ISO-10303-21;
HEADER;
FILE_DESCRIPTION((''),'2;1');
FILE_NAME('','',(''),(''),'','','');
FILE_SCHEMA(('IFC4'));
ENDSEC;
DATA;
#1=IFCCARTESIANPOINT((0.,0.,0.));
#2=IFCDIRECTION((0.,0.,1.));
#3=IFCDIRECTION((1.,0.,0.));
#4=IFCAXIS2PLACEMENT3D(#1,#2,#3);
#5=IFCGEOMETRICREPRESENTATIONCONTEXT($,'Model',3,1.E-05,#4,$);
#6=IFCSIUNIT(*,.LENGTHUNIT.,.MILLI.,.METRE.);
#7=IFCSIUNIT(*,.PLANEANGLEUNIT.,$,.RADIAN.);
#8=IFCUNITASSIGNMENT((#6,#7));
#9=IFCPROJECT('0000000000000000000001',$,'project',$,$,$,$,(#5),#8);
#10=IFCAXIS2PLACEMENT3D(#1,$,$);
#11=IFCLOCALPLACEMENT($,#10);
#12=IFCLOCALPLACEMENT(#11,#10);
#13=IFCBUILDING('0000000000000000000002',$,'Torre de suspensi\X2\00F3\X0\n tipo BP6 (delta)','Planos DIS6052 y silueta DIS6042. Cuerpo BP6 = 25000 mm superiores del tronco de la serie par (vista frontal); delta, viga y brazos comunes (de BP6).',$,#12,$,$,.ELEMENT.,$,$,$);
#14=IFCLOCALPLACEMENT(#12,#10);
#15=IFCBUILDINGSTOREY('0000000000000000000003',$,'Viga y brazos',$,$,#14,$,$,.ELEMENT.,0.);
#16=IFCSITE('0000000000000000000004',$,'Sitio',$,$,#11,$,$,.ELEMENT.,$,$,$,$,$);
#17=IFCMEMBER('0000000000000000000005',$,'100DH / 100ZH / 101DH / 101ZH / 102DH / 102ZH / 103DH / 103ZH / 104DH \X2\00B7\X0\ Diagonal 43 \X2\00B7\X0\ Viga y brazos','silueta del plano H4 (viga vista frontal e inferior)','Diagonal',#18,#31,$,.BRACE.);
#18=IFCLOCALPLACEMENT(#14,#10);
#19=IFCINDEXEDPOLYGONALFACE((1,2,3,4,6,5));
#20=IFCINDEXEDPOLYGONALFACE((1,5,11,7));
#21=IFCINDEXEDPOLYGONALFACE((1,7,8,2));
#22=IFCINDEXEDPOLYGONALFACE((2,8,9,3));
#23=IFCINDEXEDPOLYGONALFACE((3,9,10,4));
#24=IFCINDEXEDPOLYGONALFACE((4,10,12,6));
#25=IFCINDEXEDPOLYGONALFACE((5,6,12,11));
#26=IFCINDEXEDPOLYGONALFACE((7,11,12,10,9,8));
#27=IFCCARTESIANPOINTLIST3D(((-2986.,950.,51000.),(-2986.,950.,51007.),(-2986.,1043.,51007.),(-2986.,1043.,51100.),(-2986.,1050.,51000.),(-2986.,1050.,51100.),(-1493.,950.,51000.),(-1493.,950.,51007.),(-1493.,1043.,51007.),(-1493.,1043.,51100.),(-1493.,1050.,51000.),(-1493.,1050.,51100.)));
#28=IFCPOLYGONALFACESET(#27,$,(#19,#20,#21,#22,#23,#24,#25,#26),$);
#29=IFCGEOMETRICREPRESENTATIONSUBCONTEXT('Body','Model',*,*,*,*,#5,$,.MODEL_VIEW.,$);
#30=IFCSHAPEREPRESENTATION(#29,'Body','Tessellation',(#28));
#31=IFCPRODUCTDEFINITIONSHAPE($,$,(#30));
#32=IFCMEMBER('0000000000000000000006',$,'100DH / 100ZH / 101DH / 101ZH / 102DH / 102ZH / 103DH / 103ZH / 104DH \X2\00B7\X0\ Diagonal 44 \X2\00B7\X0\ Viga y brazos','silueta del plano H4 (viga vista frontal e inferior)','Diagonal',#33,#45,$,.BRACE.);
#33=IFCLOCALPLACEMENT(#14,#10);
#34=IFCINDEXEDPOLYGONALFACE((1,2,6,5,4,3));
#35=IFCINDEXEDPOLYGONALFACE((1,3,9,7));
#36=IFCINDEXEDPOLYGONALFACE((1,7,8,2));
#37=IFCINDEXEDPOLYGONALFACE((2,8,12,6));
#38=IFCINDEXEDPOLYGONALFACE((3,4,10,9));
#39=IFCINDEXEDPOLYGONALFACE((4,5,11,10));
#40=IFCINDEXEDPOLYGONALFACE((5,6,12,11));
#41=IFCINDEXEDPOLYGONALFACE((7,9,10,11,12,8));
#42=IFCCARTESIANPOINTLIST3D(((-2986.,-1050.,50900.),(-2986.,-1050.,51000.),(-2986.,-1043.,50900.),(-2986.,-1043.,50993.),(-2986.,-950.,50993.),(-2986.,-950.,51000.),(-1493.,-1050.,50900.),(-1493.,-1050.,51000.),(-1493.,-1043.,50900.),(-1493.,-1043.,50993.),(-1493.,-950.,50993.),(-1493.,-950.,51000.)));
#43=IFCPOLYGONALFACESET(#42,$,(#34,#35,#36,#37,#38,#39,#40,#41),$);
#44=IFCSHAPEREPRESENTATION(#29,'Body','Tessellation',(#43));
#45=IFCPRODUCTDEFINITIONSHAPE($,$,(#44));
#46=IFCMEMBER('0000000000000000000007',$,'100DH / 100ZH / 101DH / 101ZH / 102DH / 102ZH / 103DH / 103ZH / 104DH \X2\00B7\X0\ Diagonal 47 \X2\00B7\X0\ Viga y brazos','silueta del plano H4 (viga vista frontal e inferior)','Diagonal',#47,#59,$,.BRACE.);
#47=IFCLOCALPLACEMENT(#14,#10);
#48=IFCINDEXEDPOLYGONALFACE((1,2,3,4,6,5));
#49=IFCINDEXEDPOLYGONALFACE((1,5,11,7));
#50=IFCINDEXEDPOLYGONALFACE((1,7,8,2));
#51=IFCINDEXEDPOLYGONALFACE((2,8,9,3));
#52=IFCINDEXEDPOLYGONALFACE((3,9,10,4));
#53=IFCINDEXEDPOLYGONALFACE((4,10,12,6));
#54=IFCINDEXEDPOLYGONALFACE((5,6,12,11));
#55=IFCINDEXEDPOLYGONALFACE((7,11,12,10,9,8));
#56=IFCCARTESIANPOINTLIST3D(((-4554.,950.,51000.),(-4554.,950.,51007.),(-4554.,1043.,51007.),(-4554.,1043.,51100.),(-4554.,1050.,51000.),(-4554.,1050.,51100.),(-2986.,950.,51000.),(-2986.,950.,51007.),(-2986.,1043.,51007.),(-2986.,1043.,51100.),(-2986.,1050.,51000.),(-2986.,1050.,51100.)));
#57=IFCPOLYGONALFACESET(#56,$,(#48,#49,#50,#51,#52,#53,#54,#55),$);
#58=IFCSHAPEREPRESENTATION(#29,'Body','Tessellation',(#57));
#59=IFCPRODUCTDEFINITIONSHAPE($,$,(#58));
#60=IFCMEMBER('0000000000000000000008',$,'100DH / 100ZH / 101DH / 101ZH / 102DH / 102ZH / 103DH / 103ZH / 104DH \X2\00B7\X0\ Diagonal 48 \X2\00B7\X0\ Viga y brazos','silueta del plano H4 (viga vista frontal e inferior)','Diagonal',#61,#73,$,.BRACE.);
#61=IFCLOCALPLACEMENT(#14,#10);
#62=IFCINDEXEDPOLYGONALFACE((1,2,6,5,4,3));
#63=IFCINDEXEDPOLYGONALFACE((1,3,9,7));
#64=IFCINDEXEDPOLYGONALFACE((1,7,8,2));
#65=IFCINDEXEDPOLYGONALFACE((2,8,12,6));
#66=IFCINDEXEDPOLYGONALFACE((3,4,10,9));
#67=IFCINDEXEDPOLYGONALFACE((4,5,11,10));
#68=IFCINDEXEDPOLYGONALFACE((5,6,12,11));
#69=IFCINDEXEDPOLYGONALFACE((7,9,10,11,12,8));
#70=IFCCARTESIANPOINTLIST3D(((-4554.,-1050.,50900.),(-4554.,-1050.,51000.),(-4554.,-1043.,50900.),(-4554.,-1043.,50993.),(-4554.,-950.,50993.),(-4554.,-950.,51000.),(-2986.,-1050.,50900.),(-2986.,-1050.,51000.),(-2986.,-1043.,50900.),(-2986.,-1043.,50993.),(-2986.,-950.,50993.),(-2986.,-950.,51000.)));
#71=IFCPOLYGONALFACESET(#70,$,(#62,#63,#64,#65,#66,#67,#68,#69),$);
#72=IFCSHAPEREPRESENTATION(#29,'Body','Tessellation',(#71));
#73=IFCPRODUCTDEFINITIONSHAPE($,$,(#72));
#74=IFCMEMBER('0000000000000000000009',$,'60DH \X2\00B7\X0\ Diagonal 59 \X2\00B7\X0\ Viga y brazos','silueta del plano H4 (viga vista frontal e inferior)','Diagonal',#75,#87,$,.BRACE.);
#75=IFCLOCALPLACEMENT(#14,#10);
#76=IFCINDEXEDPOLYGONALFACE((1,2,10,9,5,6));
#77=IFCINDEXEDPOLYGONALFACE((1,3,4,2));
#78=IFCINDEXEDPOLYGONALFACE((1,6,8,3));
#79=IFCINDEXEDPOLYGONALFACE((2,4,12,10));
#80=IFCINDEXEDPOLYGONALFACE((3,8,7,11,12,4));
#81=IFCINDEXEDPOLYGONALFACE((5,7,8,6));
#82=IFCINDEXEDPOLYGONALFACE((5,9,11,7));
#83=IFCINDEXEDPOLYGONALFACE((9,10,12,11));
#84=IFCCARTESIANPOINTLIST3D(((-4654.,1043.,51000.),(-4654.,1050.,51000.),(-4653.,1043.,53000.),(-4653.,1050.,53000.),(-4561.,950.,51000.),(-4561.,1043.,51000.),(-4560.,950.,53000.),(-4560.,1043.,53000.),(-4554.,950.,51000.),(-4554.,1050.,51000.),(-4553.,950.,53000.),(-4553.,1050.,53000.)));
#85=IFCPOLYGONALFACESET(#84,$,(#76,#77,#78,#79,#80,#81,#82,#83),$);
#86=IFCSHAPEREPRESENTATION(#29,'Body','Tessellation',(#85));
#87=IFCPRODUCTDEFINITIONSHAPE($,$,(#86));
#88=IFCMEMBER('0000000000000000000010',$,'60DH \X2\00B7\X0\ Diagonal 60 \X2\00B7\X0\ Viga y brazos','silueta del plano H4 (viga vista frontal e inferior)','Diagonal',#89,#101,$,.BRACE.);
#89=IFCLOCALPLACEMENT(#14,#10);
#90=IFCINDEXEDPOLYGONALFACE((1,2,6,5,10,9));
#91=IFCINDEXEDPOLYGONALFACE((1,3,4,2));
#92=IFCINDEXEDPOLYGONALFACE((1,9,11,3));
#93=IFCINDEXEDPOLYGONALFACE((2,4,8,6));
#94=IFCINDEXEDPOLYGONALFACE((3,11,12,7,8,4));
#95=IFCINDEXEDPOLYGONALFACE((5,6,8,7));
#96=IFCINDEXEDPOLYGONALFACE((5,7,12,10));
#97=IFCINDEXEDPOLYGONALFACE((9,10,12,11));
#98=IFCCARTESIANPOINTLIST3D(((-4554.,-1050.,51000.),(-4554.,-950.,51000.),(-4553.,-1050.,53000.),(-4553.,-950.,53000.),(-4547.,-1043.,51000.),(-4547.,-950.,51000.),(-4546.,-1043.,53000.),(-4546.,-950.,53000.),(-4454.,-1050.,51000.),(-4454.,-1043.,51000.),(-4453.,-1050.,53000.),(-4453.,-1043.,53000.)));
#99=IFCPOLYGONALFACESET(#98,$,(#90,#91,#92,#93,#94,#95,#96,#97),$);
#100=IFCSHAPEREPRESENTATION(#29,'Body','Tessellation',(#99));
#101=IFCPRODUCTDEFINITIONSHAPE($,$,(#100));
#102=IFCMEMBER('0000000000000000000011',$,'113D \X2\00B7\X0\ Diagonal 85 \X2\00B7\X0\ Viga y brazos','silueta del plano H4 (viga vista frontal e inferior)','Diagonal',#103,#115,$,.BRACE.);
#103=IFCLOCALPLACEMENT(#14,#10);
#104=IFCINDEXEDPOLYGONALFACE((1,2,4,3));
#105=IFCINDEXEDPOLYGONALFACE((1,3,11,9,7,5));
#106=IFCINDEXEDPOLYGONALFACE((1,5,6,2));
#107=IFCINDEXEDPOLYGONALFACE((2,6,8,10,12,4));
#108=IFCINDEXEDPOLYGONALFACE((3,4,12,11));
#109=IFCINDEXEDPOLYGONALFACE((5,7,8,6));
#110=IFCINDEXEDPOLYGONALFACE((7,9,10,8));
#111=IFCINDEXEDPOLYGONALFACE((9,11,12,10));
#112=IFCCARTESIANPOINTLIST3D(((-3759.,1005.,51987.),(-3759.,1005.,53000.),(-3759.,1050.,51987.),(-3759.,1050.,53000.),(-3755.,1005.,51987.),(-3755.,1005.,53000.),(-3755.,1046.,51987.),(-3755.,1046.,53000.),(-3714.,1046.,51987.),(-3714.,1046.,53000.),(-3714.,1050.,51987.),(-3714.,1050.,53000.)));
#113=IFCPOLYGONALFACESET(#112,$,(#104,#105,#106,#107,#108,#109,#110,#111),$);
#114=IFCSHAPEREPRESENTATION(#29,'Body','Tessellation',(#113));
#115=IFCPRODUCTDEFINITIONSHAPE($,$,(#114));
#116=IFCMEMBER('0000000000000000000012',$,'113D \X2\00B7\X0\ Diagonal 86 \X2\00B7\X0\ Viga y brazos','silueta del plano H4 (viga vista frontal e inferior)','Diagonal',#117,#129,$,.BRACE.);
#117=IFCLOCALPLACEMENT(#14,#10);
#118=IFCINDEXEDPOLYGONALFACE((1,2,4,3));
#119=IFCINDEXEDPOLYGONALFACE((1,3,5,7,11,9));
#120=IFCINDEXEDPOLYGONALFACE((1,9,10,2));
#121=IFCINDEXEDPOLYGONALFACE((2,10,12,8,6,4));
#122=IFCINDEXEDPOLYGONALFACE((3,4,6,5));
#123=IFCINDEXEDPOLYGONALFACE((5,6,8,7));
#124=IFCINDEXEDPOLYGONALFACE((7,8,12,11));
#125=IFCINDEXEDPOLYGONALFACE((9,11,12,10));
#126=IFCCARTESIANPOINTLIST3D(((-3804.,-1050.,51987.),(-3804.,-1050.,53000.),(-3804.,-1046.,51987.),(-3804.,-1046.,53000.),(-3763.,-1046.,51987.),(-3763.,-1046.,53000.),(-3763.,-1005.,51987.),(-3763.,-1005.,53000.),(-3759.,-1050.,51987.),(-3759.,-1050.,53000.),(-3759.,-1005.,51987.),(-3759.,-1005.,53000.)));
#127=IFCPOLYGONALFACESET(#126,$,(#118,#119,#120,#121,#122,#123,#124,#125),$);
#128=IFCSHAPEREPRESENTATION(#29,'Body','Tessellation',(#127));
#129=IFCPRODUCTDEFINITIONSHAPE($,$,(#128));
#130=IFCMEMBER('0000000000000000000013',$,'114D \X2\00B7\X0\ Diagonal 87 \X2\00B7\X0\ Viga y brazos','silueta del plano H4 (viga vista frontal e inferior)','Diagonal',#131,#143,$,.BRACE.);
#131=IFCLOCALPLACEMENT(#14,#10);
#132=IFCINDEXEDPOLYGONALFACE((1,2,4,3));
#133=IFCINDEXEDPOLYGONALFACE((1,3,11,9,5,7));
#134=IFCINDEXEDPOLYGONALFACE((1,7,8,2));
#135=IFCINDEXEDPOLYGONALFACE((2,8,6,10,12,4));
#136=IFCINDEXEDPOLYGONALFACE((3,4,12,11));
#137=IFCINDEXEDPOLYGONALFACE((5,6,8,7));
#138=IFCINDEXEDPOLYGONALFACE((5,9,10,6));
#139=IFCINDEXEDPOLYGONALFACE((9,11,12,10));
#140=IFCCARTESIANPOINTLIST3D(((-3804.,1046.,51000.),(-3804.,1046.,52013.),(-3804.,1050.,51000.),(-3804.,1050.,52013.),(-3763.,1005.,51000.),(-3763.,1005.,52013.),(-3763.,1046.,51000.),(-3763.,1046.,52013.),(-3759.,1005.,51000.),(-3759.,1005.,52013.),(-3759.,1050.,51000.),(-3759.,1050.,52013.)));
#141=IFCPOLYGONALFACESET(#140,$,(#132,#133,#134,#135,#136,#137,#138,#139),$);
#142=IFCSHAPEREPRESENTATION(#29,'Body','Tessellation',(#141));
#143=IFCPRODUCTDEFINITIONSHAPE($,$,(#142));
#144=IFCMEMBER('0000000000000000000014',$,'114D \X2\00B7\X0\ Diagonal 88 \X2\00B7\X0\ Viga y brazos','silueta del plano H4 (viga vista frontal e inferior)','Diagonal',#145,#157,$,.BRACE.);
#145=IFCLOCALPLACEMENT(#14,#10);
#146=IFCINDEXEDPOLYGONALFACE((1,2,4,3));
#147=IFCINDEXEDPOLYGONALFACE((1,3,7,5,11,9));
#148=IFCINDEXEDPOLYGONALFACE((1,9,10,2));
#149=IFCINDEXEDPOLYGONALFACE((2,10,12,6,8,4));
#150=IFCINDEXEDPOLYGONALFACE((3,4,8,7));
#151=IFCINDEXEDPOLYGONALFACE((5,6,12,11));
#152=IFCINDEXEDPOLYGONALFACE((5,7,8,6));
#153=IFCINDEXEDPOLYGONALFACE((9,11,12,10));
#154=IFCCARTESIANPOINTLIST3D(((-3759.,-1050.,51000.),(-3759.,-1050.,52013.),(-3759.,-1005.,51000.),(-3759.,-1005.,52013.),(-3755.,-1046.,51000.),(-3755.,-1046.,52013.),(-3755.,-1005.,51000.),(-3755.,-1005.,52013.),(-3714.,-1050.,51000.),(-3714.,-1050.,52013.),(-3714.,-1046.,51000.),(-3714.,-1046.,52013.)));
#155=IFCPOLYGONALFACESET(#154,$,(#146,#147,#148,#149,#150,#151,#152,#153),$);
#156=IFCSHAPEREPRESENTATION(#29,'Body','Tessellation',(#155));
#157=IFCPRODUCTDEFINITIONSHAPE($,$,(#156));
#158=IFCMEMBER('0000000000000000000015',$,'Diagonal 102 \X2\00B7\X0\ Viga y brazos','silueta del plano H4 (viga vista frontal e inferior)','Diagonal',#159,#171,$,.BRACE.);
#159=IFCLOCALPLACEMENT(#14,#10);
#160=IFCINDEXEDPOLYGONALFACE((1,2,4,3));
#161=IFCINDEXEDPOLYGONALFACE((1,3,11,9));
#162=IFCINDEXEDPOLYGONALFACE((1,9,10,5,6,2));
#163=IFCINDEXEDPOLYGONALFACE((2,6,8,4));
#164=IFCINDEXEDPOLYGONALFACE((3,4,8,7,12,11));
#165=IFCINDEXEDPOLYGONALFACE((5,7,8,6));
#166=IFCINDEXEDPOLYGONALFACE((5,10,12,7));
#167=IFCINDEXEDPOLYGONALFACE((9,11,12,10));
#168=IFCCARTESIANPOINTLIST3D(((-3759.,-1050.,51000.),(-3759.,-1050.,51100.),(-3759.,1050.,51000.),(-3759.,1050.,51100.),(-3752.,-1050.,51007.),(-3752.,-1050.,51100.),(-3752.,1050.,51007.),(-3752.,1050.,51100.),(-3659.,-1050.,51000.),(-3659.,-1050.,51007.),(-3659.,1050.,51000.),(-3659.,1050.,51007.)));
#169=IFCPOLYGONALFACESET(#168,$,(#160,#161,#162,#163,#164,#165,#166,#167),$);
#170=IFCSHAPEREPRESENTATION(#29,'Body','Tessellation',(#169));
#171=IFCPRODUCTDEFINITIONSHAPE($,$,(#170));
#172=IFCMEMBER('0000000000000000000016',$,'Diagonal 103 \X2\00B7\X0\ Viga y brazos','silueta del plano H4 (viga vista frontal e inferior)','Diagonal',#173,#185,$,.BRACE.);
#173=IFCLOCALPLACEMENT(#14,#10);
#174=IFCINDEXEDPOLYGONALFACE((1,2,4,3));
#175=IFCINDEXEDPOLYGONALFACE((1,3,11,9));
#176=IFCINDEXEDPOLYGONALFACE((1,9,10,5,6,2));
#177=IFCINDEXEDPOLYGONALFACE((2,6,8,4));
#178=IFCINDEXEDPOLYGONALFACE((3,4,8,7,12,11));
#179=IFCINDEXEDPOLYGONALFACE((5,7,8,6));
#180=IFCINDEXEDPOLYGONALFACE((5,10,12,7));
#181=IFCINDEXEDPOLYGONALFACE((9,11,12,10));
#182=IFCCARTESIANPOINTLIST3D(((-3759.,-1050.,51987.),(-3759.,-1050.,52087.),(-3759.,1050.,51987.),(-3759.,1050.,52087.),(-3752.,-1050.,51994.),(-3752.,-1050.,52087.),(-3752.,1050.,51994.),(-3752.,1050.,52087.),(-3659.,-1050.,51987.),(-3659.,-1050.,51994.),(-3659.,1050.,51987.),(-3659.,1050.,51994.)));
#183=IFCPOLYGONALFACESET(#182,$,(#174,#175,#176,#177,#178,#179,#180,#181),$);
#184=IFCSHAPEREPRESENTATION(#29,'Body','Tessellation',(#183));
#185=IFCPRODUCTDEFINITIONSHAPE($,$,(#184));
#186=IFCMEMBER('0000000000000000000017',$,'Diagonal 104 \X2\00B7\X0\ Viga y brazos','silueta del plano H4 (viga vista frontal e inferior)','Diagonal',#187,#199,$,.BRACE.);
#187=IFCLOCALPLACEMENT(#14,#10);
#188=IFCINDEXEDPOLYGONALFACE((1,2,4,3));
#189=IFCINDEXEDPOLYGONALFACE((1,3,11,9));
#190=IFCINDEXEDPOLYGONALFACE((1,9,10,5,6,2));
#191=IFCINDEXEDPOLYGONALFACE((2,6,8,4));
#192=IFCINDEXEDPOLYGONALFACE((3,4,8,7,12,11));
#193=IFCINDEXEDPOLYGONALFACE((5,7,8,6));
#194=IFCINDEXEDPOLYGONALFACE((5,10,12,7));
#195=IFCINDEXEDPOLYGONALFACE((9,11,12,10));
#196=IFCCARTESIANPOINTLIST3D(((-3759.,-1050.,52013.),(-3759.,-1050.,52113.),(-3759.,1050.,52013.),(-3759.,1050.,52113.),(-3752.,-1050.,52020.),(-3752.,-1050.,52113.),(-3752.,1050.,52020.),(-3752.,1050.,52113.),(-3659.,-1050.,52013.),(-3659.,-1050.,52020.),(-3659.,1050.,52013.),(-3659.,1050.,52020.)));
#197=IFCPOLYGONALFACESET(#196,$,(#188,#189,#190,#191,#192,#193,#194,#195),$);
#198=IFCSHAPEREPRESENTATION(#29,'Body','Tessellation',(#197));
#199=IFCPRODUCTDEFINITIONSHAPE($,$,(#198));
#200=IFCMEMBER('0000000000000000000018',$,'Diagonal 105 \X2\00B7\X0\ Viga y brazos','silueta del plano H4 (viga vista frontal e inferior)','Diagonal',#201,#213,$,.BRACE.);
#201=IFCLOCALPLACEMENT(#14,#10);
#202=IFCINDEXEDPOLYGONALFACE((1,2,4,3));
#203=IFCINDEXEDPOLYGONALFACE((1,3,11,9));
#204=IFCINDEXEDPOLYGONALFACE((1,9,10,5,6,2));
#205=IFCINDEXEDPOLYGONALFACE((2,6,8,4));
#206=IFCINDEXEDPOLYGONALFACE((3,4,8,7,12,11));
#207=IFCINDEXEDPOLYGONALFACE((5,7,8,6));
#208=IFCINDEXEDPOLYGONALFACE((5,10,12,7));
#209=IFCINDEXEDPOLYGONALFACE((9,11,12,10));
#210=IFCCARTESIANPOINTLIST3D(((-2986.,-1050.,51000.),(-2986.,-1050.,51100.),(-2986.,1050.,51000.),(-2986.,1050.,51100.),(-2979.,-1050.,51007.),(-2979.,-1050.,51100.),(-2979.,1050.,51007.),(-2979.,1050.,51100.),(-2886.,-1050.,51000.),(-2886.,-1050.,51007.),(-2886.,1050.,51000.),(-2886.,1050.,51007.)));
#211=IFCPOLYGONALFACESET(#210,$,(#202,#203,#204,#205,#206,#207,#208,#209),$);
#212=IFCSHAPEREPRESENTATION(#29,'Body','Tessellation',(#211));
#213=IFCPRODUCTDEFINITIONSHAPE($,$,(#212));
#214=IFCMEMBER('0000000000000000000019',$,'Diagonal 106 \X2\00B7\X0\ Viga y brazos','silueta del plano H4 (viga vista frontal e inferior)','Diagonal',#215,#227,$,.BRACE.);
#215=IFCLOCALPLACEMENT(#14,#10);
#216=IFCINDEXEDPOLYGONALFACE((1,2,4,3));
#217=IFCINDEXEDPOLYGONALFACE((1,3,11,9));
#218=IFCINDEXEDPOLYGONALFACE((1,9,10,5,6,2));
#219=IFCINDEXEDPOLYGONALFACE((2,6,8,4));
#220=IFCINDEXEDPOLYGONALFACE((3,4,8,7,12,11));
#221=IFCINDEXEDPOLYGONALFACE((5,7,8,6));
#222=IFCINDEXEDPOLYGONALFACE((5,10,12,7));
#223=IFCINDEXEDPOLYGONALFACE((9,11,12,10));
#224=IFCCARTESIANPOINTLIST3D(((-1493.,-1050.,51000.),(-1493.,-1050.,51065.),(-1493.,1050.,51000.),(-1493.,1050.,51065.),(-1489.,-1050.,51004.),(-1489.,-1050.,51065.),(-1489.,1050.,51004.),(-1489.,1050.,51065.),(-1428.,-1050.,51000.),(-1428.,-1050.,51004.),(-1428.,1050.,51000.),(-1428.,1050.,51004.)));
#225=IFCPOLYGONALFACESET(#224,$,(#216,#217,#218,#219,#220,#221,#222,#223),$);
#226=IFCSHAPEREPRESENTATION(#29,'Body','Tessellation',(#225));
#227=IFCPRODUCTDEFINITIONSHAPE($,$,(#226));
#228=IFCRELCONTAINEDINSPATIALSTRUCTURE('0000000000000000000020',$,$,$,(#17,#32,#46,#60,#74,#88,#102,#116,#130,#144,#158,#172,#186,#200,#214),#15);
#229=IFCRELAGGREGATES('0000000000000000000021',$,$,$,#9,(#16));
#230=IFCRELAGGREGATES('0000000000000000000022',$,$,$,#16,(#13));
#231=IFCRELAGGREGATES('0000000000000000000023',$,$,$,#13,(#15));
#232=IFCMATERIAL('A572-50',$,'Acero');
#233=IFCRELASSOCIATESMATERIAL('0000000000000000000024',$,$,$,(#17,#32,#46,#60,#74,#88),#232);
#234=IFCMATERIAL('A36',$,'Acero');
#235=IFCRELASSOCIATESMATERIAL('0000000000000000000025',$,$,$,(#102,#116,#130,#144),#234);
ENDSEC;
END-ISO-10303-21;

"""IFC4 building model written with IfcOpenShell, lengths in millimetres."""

from ifc_helpers import new_model, si_unit, frame, frame_2d, origin, origin_with_axes, place, context, subcontext, project, spatial, l_section, extrude, material, element, save


model = new_model("IFC4")

# Units and contexts
model_context = context("Model", 3, precision=1e-05, world=origin_with_axes())
body_context = subcontext(model_context, "Body", "Model", "MODEL_VIEW")
ifc_project = project(units=[si_unit("LENGTHUNIT", "METRE", prefix="MILLI"), si_unit("PLANEANGLEUNIT", "RADIAN")], contexts=[model_context])

# Site, building, storey
site_placement = place(None, origin())
site = spatial("IfcSite", under=ifc_project, at=site_placement, Name="Sitio", CompositionType="ELEMENT")
building_placement = place(site_placement, origin())
building = spatial("IfcBuilding", under=site, at=building_placement, Name="Torre de suspensión tipo BP6 (delta)", Description="Planos DIS6052 y silueta DIS6042. Cuerpo BP6 = 25000 mm superiores del tronco de la serie par (vista frontal); delta, viga y brazos comunes (de BP6).", CompositionType="ELEMENT")
storey_placement = place(building_placement, origin())
storey = spatial("IfcBuildingStorey", under=building, at=storey_placement, Name="Viga y brazos", CompositionType="ELEMENT", Elevation=0.0)

# Members
ifc_material_1 = material(Name="A572-50", Category="Acero")
ifc_material_2 = material(Name="A36", Category="Acero")
for number, where, z_axis, x_axis, name in (
    (1, (-1493.0, 1050.0, 51000.0), (-1.0, 0.0, 0.0), (0.0, -1.0, 0.0), "100DH / 100ZH / 101DH / 101ZH / 102DH / 102ZH / 103DH / 103ZH / 104DH · Diagonal 43 · Viga y brazos"),
    (2, (-1493.0, -1050.0, 51000.0), (-1.0, 0.0, 0.0), (0.0, 1.0, 0.0), "100DH / 100ZH / 101DH / 101ZH / 102DH / 102ZH / 103DH / 103ZH / 104DH · Diagonal 44 · Viga y brazos"),
):
    element("IfcMember", number, at=place(storey_placement, frame(where, z_axis=z_axis, x_axis=x_axis)), inside=storey, material=ifc_material_1, Name=name, Description="silueta del plano H4 (viga vista frontal e inferior)", ObjectType="Diagonal", PredefinedType="BRACE", context=body_context, shape_type="SweptSolid", body=[
        extrude(l_section(Depth=100.0, Width=100.0, Thickness=7.0, at=frame_2d((50.0, 50.0))), None, (0.0, 0.0, 1.0), 1493.0),
    ])
for number, where, z_axis, x_axis, name in (
    (3, (-2986.0, 1050.0, 51000.0), (-1.0, 0.0, 0.0), (0.0, -1.0, 0.0), "100DH / 100ZH / 101DH / 101ZH / 102DH / 102ZH / 103DH / 103ZH / 104DH · Diagonal 47 · Viga y brazos"),
    (4, (-2986.0, -1050.0, 51000.0), (-1.0, 0.0, 0.0), (0.0, 1.0, 0.0), "100DH / 100ZH / 101DH / 101ZH / 102DH / 102ZH / 103DH / 103ZH / 104DH · Diagonal 48 · Viga y brazos"),
):
    element("IfcMember", number, at=place(storey_placement, frame(where, z_axis=z_axis, x_axis=x_axis)), inside=storey, material=ifc_material_1, Name=name, Description="silueta del plano H4 (viga vista frontal e inferior)", ObjectType="Diagonal", PredefinedType="BRACE", context=body_context, shape_type="SweptSolid", body=[
        extrude(l_section(Depth=100.0, Width=100.0, Thickness=7.0, at=frame_2d((50.0, 50.0))), None, (0.0, 0.0, 1.0), 1568.0),
    ])
for number, where, z_axis, x_axis, name in (
    (5, (-4553.0, 1050.0, 53000.0), (-0.0005, 0.0, -1.0), (0.0, -1.0, 0.0), "60DH · Diagonal 59 · Viga y brazos"),
    (6, (-4553.0, -1050.0, 53000.0), (-0.0005, 0.0, -1.0), (0.0, 1.0, 0.0), "60DH · Diagonal 60 · Viga y brazos"),
):
    element("IfcMember", number, at=place(storey_placement, frame(where, z_axis=z_axis, x_axis=x_axis)), inside=storey, material=ifc_material_1, Name=name, Description="silueta del plano H4 (viga vista frontal e inferior)", ObjectType="Diagonal", PredefinedType="BRACE", context=body_context, shape_type="SweptSolid", body=[
        extrude(l_section(Depth=100.0, Width=100.0, Thickness=7.0, at=frame_2d((50.0, 50.0))), None, (0.0, 0.0, 1.0), 2000.0),
    ])
for number, where, z_axis, x_axis, name in (
    (7, (-3759.0, 1050.0, 51987.0), (0.0, 0.0, 1.0), (0.0, -1.0, 0.0), "113D · Diagonal 85 · Viga y brazos"),
    (8, (-3759.0, -1050.0, 51987.0), (0.0, 0.0, 1.0), (0.0, 1.0, 0.0), "113D · Diagonal 86 · Viga y brazos"),
    (9, (-3759.0, 1050.0, 52013.0), (0.0, 0.0, -1.0), (0.0, -1.0, 0.0), "114D · Diagonal 87 · Viga y brazos"),
    (10, (-3759.0, -1050.0, 52013.0), (0.0, 0.0, -1.0), (0.0, 1.0, 0.0), "114D · Diagonal 88 · Viga y brazos"),
):
    element("IfcMember", number, at=place(storey_placement, frame(where, z_axis=z_axis, x_axis=x_axis)), inside=storey, material=ifc_material_2, Name=name, Description="silueta del plano H4 (viga vista frontal e inferior)", ObjectType="Diagonal", PredefinedType="BRACE", context=body_context, shape_type="SweptSolid", body=[
        extrude(l_section(Depth=45.0, Width=45.0, Thickness=4.0, at=frame_2d((22.5, 22.5))), None, (0.0, 0.0, 1.0), 1013.0),
    ])
for number, where, z_axis, x_axis, name in (
    (11, (-3759.0, 1050.0, 51000.0), (0.0, -1.0, 0.0), (1.0, 0.0, 0.0), "Diagonal 102 · Viga y brazos"),
    (12, (-3759.0, 1050.0, 51987.0), (0.0, -1.0, 0.0), (1.0, 0.0, 0.0), "Diagonal 103 · Viga y brazos"),
    (13, (-3759.0, 1050.0, 52013.0), (0.0, -1.0, 0.0), (1.0, 0.0, 0.0), "Diagonal 104 · Viga y brazos"),
    (14, (-2986.0, 1050.0, 51000.0), (0.0, -1.0, 0.0), (1.0, 0.0, 0.0), "Diagonal 105 · Viga y brazos"),
):
    element("IfcMember", number, at=place(storey_placement, frame(where, z_axis=z_axis, x_axis=x_axis)), inside=storey, Name=name, Description="silueta del plano H4 (viga vista frontal e inferior)", ObjectType="Diagonal", PredefinedType="BRACE", context=body_context, shape_type="SweptSolid", body=[
        extrude(l_section(Depth=100.0, Width=100.0, Thickness=7.0, at=frame_2d((50.0, 50.0))), None, (0.0, 0.0, 1.0), 2100.0),
    ])
member_placement = place(storey_placement, frame((-1493.0, 1050.0, 51000.0), z_axis=(0.0, -1.0, 0.0), x_axis=(1.0, 0.0, 0.0)))
element("IfcMember", 15, at=member_placement, inside=storey, Name="Diagonal 106 · Viga y brazos", Description="silueta del plano H4 (viga vista frontal e inferior)", ObjectType="Diagonal", PredefinedType="BRACE", context=body_context, shape_type="SweptSolid", body=[
    extrude(l_section(Depth=65.0, Width=65.0, Thickness=4.0, at=frame_2d((32.5, 32.5))), None, (0.0, 0.0, 1.0), 2100.0),
])

save(model, "model.ifc")
